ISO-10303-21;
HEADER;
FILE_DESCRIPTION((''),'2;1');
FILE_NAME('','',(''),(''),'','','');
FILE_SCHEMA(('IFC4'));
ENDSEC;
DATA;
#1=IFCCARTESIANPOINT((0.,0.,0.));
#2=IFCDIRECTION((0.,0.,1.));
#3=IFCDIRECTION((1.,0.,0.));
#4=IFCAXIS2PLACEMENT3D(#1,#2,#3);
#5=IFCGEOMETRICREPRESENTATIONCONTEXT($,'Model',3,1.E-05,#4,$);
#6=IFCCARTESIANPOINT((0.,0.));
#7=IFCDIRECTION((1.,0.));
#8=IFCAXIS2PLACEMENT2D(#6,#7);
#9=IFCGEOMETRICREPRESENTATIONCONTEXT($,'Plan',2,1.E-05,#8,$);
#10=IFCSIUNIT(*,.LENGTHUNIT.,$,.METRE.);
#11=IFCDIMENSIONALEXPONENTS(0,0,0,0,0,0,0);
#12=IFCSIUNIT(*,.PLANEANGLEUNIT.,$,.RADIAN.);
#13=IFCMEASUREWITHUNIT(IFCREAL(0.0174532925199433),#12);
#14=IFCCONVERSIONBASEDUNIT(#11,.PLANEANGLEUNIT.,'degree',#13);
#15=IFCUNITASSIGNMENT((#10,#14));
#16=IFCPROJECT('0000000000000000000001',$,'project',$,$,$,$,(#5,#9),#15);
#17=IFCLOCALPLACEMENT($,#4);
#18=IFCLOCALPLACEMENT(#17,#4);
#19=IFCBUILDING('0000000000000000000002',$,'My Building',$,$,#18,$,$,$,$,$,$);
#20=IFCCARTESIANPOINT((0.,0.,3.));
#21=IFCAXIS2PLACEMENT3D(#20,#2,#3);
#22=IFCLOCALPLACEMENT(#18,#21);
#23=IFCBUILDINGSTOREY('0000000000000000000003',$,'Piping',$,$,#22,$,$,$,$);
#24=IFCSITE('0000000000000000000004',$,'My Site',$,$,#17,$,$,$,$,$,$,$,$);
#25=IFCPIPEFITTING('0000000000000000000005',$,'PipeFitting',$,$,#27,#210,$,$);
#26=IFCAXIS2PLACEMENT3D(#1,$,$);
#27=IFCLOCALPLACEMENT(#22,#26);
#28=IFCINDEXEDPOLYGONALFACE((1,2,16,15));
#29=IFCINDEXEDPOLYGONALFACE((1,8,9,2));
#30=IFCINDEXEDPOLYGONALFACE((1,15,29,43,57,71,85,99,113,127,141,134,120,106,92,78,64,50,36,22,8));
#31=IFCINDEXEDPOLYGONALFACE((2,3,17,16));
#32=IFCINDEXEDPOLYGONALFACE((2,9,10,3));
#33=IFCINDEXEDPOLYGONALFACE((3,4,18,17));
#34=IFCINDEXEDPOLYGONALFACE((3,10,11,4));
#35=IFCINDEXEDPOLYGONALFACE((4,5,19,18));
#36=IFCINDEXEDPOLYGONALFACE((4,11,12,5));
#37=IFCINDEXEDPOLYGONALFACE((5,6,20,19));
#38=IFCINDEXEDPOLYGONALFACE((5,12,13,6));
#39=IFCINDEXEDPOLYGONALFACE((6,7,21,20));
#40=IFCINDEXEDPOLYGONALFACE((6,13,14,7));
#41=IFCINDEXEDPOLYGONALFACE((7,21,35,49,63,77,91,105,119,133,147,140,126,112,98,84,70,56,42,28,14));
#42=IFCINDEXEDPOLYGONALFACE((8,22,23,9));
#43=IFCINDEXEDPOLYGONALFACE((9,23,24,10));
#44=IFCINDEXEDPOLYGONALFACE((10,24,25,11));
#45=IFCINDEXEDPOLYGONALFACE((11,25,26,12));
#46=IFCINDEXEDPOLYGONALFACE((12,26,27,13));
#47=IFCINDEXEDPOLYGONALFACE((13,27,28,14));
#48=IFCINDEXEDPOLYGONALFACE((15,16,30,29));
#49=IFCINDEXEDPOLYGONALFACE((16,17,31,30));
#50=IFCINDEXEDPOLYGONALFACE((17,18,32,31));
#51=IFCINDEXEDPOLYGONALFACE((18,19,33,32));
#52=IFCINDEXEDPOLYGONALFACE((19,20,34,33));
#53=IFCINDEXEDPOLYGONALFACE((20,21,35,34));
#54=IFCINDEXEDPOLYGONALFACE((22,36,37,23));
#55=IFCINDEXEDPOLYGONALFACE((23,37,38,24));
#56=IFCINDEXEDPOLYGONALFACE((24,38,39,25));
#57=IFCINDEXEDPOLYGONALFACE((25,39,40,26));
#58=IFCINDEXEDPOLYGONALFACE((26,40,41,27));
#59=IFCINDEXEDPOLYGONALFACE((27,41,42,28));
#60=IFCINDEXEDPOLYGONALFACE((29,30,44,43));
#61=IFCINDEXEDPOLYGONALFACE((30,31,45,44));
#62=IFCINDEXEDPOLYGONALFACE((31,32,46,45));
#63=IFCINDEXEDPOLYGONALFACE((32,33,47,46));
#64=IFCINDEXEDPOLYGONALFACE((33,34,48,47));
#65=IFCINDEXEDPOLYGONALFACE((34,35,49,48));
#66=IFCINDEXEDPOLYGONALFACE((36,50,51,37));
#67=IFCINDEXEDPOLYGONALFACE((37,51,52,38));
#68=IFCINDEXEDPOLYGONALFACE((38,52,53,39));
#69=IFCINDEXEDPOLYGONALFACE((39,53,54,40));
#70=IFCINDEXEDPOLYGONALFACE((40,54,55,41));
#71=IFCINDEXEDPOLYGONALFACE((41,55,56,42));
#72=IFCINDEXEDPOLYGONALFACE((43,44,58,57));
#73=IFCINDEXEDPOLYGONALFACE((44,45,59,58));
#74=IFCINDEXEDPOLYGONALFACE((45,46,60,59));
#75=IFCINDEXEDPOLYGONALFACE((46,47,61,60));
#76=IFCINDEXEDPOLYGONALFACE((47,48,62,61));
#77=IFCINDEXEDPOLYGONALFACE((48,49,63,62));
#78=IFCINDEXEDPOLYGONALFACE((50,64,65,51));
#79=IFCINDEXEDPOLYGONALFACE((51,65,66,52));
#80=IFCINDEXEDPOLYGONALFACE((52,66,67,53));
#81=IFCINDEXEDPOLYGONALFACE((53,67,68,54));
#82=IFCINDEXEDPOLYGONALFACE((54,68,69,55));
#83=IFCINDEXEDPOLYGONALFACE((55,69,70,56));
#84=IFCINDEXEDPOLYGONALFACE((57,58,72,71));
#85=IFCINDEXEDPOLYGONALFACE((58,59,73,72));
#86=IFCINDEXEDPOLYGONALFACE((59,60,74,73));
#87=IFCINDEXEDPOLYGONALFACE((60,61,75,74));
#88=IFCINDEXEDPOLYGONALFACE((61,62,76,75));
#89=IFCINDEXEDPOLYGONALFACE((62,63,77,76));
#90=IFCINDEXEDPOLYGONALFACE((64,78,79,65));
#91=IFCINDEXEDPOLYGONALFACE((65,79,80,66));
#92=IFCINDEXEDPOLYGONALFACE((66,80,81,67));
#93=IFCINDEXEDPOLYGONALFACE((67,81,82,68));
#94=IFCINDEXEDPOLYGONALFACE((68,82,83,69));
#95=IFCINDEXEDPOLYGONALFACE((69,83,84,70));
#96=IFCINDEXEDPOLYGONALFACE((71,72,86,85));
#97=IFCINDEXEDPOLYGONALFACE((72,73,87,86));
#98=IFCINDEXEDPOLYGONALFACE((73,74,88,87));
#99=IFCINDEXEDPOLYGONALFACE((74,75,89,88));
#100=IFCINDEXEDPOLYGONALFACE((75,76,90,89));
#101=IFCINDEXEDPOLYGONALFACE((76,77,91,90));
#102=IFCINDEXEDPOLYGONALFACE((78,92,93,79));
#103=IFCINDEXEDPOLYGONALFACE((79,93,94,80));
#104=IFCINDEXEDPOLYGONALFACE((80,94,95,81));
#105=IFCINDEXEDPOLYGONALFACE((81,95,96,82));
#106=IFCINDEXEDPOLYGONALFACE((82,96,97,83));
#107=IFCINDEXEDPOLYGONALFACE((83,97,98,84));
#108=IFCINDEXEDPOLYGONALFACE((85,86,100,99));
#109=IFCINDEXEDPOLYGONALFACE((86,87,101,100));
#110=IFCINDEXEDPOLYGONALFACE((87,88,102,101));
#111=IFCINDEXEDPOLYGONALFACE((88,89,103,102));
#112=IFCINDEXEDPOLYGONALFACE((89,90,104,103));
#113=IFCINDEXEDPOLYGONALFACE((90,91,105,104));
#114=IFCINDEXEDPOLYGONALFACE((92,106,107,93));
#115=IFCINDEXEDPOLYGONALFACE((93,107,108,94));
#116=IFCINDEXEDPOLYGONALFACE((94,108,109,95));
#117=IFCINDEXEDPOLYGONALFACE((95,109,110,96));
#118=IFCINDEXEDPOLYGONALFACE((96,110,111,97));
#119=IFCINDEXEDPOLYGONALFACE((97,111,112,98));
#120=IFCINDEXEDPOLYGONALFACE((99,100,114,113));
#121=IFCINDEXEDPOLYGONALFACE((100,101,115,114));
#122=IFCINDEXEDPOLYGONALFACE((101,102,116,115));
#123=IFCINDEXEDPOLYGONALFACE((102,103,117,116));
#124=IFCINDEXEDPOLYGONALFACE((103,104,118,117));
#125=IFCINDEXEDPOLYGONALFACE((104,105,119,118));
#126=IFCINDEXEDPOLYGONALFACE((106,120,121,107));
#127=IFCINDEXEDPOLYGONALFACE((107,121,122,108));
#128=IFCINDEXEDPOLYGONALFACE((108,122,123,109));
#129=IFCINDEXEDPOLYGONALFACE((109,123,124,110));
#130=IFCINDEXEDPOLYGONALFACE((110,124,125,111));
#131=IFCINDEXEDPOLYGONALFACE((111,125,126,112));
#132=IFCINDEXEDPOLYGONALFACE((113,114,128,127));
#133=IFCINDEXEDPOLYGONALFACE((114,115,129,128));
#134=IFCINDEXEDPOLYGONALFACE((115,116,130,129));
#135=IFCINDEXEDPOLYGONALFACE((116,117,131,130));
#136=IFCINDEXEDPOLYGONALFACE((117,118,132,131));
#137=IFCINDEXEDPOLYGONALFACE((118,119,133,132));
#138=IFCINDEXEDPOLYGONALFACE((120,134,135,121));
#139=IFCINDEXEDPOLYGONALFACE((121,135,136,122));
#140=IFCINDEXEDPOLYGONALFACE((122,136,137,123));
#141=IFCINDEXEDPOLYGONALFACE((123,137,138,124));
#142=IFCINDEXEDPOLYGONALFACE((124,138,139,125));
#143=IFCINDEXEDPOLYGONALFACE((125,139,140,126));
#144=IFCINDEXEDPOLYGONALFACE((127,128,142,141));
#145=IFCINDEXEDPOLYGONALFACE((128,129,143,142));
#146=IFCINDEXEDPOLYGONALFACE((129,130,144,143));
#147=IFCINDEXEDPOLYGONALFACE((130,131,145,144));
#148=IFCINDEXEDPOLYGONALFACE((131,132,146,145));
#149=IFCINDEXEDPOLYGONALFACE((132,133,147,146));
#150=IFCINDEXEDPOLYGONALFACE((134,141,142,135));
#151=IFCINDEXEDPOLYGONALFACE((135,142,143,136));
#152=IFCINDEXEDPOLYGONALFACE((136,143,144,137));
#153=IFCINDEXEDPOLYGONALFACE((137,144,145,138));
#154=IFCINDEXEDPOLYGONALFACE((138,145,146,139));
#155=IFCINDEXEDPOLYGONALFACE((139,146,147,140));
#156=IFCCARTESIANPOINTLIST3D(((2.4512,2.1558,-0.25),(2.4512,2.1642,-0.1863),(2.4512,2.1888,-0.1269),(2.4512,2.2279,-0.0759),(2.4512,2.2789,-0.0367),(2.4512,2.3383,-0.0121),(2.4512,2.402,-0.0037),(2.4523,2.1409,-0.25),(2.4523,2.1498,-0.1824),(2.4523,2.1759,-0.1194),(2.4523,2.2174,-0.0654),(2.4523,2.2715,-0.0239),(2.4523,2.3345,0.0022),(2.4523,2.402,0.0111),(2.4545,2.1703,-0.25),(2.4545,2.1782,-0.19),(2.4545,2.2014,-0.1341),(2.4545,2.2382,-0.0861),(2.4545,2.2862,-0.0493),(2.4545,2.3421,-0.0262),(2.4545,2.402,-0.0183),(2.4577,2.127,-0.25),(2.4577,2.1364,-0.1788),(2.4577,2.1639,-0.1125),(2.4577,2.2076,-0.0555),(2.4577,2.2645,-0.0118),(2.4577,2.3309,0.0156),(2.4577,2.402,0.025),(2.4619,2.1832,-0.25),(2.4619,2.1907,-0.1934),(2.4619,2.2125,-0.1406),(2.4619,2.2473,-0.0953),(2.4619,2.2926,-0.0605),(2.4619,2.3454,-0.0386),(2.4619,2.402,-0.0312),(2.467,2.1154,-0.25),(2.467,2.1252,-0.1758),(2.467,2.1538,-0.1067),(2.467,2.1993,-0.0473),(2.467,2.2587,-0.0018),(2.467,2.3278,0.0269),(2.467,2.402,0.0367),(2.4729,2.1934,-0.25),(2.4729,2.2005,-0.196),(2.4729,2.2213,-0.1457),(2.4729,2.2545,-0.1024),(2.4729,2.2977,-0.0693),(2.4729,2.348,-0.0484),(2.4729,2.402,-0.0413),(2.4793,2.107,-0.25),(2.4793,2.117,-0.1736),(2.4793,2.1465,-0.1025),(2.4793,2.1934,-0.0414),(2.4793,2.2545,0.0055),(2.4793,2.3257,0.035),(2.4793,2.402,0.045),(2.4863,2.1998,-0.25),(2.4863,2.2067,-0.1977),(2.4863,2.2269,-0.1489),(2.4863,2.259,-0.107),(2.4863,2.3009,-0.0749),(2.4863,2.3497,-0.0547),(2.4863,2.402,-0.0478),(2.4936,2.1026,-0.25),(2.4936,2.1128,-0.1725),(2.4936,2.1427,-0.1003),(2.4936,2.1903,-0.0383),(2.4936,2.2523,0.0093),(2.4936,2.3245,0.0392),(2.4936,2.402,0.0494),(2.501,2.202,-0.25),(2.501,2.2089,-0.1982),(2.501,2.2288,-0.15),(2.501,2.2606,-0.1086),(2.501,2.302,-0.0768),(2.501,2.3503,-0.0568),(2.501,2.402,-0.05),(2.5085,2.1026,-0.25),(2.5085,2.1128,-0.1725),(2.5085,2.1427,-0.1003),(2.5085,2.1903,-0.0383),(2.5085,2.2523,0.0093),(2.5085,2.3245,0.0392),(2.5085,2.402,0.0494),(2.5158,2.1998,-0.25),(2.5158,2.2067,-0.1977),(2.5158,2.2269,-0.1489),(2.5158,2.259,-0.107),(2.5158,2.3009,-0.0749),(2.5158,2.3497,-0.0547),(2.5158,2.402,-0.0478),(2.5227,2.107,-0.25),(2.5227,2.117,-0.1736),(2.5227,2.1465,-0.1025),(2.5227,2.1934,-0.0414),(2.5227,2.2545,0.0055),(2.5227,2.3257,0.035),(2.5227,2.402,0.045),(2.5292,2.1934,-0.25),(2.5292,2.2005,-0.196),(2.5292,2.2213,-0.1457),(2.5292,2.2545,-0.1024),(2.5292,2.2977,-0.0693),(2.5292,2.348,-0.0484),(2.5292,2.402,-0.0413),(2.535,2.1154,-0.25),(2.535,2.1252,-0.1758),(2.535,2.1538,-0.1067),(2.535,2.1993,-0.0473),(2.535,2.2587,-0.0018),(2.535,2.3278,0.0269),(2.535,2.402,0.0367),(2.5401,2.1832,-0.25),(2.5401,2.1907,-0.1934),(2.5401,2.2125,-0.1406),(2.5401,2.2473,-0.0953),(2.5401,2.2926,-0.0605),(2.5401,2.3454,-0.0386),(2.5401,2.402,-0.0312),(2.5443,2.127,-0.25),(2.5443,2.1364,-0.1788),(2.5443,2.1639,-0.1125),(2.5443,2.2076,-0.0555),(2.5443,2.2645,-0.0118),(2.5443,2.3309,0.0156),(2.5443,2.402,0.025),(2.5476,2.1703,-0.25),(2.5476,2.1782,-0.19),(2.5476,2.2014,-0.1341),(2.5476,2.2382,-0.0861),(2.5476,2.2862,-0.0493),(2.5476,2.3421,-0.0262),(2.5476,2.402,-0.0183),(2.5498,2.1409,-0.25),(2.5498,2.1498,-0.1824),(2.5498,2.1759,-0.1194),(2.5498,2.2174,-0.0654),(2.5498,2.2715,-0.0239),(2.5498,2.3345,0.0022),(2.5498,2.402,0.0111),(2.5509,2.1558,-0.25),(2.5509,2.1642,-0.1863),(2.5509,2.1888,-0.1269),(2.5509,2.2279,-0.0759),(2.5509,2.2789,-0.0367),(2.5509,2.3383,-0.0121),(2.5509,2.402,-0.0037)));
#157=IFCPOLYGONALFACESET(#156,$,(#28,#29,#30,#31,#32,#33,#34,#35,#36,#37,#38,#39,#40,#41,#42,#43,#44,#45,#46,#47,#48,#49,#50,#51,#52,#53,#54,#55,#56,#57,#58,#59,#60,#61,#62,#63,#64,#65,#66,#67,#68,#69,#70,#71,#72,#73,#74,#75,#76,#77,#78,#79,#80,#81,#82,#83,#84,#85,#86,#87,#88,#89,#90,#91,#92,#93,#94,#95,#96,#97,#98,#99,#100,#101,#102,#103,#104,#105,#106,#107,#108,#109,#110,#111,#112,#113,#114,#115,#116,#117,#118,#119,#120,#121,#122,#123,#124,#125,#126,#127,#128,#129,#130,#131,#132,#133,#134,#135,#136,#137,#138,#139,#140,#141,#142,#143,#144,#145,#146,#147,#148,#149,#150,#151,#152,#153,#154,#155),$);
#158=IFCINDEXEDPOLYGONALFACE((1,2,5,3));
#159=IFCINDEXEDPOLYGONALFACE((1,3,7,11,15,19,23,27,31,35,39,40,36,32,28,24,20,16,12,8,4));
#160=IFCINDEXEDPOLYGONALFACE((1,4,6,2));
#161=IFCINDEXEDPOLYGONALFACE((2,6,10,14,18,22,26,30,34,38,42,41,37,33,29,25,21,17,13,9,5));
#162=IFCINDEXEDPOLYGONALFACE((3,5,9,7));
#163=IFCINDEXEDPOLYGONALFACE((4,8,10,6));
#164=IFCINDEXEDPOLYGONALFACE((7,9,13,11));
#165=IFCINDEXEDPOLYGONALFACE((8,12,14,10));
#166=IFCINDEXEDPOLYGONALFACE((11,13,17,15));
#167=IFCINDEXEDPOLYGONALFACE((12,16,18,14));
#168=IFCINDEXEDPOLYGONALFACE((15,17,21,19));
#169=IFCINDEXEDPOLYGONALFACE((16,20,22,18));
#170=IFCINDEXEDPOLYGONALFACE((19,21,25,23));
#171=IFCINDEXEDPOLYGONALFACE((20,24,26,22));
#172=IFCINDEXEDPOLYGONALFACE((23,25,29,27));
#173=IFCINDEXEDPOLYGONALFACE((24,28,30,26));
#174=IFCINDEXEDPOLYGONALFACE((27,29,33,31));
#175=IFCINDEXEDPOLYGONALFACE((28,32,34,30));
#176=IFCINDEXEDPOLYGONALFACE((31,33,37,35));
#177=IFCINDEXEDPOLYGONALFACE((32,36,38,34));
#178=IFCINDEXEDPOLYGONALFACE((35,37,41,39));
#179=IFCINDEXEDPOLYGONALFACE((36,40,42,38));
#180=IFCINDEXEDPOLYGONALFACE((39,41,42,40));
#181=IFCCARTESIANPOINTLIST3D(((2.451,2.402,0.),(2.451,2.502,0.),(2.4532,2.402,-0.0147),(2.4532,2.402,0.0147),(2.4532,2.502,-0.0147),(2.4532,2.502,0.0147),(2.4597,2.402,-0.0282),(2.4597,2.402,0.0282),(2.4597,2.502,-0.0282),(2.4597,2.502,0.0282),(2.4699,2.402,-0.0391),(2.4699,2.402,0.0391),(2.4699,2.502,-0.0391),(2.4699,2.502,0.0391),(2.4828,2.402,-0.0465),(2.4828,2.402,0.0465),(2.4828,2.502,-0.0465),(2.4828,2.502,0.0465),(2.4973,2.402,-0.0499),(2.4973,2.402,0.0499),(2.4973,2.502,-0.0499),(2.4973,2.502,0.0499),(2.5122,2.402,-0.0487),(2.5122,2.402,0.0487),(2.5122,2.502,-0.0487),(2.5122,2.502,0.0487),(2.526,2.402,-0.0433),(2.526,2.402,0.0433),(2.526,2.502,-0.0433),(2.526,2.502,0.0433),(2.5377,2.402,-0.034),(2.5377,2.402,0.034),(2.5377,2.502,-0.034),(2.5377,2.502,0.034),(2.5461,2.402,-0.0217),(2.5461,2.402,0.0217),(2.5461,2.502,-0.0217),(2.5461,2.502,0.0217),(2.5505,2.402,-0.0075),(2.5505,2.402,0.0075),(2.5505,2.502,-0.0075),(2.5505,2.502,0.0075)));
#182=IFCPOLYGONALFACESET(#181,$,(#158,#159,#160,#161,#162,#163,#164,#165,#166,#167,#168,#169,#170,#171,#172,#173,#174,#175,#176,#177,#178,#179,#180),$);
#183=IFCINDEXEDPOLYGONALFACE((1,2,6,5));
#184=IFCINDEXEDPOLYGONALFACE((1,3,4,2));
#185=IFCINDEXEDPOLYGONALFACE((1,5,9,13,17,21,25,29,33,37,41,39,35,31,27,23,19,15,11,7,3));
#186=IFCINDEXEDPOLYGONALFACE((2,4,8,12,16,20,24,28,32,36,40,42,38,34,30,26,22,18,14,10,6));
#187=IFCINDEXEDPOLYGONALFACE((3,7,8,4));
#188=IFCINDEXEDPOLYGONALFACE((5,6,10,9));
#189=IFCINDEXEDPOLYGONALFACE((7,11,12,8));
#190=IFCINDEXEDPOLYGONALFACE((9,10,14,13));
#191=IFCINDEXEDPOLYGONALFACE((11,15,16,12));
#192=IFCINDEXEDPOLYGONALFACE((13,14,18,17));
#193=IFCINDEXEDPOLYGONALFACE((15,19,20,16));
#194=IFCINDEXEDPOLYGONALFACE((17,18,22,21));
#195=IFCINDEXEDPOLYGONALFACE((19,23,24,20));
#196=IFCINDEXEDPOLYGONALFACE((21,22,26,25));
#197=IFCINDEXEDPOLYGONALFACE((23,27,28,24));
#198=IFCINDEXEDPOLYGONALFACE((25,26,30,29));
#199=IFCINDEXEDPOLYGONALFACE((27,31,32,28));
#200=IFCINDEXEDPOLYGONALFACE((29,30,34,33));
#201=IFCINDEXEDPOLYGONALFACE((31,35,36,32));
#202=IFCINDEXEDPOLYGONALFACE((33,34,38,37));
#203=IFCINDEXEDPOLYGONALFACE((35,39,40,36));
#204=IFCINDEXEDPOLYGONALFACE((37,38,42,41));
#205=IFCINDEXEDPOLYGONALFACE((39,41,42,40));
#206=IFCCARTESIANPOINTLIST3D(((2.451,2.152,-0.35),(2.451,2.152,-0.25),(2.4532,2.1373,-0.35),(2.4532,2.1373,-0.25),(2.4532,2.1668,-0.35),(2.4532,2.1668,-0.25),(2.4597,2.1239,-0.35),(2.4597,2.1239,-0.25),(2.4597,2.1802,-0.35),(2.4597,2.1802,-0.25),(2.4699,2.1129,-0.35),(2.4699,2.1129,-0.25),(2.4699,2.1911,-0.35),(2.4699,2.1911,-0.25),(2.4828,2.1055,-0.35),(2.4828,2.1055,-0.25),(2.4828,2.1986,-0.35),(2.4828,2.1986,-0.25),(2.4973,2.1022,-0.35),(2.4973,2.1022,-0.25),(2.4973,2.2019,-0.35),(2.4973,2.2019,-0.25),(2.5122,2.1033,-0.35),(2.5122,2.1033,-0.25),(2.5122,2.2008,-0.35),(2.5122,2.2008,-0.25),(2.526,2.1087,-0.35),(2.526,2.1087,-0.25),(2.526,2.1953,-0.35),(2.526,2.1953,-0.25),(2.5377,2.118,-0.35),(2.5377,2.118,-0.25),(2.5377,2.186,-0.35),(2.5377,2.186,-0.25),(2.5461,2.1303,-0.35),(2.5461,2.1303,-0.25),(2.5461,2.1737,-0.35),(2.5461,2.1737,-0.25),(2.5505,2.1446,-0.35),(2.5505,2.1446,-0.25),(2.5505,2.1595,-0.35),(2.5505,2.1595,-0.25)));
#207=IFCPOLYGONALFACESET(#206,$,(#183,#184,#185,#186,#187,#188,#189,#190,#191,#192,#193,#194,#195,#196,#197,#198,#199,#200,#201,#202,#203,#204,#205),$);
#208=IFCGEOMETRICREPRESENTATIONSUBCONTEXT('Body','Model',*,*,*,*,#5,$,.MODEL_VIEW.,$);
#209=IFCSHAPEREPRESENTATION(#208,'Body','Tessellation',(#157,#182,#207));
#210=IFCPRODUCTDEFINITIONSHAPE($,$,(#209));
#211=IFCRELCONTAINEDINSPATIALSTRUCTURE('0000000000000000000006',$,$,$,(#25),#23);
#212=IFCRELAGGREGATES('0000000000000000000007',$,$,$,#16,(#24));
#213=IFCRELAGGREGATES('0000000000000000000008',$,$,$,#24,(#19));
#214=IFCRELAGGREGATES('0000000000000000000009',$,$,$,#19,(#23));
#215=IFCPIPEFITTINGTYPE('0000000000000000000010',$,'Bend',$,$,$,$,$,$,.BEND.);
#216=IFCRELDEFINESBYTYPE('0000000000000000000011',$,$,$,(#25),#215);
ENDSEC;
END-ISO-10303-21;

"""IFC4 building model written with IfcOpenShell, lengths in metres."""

from ifc_helpers import new_model, entity, si_unit, converted_unit, frame, origin_with_axes, origin_2d_with_axis, place, context, subcontext, project, spatial, circle, extrude, source, transform, mapped, type_object, type_shapes, element, save


model = new_model("IFC4")

# Units and contexts
model_context = context("Model", 3, precision=1e-05, world=origin_with_axes())
plan_context = context("Plan", 2, precision=1e-05, world=origin_2d_with_axis())
body_context = subcontext(model_context, "Body", "Model", "MODEL_VIEW")
ifc_project = project(units=[si_unit("LENGTHUNIT", "METRE"), converted_unit("PLANEANGLEUNIT", "degree", entity("IfcReal", 0.0174532925199433), si_unit("PLANEANGLEUNIT", "RADIAN"), dimensions=[0, 0, 0, 0, 0, 0, 0])], contexts=[model_context, plan_context])

# Site, building, storey
site_placement = place(None, origin_with_axes())
site = spatial("IfcSite", under=ifc_project, at=site_placement, Name="My Site")
building_placement = place(site_placement, origin_with_axes())
building = spatial("IfcBuilding", under=site, at=building_placement, Name="My Building")
storey_placement = place(building_placement, frame((0.0, 0.0, 3.0), z_axis=(0.0, 0.0, 1.0), x_axis=(1.0, 0.0, 0.0)))
storey = spatial("IfcBuildingStorey", under=building, at=storey_placement, Name="Piping")

# Pipe fitting
pipe_fitting_type = type_object("IfcPipeFittingType", Name="Bend", PredefinedType="BEND")
shared_shape = source(origin_with_axes(), body_context, "Body", "SolidModel", [
    entity("IfcSweptDiskSolid", entity("IfcIndexedPolyCurve", entity("IfcCartesianPointList3D", [[0.0, 0.0, -0.1], [0.0, -0.0732, -0.2768], [0.0, -0.25, -0.35]]), [entity("IfcArcIndex", [1, 2, 3])]), 0.05),
    extrude(circle(Radius=0.05), origin_with_axes(), (0.0, 0.0, -1.0), 0.1),
    extrude(circle(Radius=0.05), frame((0.0, -0.25, -0.35), z_axis=(0.0, -1.0, 0.0), x_axis=(1.0, 0.0, 0.0)), (0.0, 0.0, 1.0), 0.1),
])
type_shapes(pipe_fitting_type, [shared_shape])
for number, where, z_axis, x_axis, name in (
    (1, (2.501, 2.502, 0.0), (0.0, 1.0, 0.0), (-1.0, 0.0, 0.0), "PipeFitting"),
):
    element("IfcPipeFitting", number, at=place(storey_placement, frame(where, z_axis=z_axis, x_axis=x_axis)), inside=storey, type_object=pipe_fitting_type, Name=name, context=body_context, shape_type="MappedRepresentation", body=[
        mapped(shared_shape, transform((0.0, 0.0, 0.0), x_axis=(1.0, 0.0, 0.0), y_axis=(0.0, 1.0, 0.0), z_axis=(0.0, 0.0, 1.0), scale=1.0)),
    ])

save(model, "model.ifc")
